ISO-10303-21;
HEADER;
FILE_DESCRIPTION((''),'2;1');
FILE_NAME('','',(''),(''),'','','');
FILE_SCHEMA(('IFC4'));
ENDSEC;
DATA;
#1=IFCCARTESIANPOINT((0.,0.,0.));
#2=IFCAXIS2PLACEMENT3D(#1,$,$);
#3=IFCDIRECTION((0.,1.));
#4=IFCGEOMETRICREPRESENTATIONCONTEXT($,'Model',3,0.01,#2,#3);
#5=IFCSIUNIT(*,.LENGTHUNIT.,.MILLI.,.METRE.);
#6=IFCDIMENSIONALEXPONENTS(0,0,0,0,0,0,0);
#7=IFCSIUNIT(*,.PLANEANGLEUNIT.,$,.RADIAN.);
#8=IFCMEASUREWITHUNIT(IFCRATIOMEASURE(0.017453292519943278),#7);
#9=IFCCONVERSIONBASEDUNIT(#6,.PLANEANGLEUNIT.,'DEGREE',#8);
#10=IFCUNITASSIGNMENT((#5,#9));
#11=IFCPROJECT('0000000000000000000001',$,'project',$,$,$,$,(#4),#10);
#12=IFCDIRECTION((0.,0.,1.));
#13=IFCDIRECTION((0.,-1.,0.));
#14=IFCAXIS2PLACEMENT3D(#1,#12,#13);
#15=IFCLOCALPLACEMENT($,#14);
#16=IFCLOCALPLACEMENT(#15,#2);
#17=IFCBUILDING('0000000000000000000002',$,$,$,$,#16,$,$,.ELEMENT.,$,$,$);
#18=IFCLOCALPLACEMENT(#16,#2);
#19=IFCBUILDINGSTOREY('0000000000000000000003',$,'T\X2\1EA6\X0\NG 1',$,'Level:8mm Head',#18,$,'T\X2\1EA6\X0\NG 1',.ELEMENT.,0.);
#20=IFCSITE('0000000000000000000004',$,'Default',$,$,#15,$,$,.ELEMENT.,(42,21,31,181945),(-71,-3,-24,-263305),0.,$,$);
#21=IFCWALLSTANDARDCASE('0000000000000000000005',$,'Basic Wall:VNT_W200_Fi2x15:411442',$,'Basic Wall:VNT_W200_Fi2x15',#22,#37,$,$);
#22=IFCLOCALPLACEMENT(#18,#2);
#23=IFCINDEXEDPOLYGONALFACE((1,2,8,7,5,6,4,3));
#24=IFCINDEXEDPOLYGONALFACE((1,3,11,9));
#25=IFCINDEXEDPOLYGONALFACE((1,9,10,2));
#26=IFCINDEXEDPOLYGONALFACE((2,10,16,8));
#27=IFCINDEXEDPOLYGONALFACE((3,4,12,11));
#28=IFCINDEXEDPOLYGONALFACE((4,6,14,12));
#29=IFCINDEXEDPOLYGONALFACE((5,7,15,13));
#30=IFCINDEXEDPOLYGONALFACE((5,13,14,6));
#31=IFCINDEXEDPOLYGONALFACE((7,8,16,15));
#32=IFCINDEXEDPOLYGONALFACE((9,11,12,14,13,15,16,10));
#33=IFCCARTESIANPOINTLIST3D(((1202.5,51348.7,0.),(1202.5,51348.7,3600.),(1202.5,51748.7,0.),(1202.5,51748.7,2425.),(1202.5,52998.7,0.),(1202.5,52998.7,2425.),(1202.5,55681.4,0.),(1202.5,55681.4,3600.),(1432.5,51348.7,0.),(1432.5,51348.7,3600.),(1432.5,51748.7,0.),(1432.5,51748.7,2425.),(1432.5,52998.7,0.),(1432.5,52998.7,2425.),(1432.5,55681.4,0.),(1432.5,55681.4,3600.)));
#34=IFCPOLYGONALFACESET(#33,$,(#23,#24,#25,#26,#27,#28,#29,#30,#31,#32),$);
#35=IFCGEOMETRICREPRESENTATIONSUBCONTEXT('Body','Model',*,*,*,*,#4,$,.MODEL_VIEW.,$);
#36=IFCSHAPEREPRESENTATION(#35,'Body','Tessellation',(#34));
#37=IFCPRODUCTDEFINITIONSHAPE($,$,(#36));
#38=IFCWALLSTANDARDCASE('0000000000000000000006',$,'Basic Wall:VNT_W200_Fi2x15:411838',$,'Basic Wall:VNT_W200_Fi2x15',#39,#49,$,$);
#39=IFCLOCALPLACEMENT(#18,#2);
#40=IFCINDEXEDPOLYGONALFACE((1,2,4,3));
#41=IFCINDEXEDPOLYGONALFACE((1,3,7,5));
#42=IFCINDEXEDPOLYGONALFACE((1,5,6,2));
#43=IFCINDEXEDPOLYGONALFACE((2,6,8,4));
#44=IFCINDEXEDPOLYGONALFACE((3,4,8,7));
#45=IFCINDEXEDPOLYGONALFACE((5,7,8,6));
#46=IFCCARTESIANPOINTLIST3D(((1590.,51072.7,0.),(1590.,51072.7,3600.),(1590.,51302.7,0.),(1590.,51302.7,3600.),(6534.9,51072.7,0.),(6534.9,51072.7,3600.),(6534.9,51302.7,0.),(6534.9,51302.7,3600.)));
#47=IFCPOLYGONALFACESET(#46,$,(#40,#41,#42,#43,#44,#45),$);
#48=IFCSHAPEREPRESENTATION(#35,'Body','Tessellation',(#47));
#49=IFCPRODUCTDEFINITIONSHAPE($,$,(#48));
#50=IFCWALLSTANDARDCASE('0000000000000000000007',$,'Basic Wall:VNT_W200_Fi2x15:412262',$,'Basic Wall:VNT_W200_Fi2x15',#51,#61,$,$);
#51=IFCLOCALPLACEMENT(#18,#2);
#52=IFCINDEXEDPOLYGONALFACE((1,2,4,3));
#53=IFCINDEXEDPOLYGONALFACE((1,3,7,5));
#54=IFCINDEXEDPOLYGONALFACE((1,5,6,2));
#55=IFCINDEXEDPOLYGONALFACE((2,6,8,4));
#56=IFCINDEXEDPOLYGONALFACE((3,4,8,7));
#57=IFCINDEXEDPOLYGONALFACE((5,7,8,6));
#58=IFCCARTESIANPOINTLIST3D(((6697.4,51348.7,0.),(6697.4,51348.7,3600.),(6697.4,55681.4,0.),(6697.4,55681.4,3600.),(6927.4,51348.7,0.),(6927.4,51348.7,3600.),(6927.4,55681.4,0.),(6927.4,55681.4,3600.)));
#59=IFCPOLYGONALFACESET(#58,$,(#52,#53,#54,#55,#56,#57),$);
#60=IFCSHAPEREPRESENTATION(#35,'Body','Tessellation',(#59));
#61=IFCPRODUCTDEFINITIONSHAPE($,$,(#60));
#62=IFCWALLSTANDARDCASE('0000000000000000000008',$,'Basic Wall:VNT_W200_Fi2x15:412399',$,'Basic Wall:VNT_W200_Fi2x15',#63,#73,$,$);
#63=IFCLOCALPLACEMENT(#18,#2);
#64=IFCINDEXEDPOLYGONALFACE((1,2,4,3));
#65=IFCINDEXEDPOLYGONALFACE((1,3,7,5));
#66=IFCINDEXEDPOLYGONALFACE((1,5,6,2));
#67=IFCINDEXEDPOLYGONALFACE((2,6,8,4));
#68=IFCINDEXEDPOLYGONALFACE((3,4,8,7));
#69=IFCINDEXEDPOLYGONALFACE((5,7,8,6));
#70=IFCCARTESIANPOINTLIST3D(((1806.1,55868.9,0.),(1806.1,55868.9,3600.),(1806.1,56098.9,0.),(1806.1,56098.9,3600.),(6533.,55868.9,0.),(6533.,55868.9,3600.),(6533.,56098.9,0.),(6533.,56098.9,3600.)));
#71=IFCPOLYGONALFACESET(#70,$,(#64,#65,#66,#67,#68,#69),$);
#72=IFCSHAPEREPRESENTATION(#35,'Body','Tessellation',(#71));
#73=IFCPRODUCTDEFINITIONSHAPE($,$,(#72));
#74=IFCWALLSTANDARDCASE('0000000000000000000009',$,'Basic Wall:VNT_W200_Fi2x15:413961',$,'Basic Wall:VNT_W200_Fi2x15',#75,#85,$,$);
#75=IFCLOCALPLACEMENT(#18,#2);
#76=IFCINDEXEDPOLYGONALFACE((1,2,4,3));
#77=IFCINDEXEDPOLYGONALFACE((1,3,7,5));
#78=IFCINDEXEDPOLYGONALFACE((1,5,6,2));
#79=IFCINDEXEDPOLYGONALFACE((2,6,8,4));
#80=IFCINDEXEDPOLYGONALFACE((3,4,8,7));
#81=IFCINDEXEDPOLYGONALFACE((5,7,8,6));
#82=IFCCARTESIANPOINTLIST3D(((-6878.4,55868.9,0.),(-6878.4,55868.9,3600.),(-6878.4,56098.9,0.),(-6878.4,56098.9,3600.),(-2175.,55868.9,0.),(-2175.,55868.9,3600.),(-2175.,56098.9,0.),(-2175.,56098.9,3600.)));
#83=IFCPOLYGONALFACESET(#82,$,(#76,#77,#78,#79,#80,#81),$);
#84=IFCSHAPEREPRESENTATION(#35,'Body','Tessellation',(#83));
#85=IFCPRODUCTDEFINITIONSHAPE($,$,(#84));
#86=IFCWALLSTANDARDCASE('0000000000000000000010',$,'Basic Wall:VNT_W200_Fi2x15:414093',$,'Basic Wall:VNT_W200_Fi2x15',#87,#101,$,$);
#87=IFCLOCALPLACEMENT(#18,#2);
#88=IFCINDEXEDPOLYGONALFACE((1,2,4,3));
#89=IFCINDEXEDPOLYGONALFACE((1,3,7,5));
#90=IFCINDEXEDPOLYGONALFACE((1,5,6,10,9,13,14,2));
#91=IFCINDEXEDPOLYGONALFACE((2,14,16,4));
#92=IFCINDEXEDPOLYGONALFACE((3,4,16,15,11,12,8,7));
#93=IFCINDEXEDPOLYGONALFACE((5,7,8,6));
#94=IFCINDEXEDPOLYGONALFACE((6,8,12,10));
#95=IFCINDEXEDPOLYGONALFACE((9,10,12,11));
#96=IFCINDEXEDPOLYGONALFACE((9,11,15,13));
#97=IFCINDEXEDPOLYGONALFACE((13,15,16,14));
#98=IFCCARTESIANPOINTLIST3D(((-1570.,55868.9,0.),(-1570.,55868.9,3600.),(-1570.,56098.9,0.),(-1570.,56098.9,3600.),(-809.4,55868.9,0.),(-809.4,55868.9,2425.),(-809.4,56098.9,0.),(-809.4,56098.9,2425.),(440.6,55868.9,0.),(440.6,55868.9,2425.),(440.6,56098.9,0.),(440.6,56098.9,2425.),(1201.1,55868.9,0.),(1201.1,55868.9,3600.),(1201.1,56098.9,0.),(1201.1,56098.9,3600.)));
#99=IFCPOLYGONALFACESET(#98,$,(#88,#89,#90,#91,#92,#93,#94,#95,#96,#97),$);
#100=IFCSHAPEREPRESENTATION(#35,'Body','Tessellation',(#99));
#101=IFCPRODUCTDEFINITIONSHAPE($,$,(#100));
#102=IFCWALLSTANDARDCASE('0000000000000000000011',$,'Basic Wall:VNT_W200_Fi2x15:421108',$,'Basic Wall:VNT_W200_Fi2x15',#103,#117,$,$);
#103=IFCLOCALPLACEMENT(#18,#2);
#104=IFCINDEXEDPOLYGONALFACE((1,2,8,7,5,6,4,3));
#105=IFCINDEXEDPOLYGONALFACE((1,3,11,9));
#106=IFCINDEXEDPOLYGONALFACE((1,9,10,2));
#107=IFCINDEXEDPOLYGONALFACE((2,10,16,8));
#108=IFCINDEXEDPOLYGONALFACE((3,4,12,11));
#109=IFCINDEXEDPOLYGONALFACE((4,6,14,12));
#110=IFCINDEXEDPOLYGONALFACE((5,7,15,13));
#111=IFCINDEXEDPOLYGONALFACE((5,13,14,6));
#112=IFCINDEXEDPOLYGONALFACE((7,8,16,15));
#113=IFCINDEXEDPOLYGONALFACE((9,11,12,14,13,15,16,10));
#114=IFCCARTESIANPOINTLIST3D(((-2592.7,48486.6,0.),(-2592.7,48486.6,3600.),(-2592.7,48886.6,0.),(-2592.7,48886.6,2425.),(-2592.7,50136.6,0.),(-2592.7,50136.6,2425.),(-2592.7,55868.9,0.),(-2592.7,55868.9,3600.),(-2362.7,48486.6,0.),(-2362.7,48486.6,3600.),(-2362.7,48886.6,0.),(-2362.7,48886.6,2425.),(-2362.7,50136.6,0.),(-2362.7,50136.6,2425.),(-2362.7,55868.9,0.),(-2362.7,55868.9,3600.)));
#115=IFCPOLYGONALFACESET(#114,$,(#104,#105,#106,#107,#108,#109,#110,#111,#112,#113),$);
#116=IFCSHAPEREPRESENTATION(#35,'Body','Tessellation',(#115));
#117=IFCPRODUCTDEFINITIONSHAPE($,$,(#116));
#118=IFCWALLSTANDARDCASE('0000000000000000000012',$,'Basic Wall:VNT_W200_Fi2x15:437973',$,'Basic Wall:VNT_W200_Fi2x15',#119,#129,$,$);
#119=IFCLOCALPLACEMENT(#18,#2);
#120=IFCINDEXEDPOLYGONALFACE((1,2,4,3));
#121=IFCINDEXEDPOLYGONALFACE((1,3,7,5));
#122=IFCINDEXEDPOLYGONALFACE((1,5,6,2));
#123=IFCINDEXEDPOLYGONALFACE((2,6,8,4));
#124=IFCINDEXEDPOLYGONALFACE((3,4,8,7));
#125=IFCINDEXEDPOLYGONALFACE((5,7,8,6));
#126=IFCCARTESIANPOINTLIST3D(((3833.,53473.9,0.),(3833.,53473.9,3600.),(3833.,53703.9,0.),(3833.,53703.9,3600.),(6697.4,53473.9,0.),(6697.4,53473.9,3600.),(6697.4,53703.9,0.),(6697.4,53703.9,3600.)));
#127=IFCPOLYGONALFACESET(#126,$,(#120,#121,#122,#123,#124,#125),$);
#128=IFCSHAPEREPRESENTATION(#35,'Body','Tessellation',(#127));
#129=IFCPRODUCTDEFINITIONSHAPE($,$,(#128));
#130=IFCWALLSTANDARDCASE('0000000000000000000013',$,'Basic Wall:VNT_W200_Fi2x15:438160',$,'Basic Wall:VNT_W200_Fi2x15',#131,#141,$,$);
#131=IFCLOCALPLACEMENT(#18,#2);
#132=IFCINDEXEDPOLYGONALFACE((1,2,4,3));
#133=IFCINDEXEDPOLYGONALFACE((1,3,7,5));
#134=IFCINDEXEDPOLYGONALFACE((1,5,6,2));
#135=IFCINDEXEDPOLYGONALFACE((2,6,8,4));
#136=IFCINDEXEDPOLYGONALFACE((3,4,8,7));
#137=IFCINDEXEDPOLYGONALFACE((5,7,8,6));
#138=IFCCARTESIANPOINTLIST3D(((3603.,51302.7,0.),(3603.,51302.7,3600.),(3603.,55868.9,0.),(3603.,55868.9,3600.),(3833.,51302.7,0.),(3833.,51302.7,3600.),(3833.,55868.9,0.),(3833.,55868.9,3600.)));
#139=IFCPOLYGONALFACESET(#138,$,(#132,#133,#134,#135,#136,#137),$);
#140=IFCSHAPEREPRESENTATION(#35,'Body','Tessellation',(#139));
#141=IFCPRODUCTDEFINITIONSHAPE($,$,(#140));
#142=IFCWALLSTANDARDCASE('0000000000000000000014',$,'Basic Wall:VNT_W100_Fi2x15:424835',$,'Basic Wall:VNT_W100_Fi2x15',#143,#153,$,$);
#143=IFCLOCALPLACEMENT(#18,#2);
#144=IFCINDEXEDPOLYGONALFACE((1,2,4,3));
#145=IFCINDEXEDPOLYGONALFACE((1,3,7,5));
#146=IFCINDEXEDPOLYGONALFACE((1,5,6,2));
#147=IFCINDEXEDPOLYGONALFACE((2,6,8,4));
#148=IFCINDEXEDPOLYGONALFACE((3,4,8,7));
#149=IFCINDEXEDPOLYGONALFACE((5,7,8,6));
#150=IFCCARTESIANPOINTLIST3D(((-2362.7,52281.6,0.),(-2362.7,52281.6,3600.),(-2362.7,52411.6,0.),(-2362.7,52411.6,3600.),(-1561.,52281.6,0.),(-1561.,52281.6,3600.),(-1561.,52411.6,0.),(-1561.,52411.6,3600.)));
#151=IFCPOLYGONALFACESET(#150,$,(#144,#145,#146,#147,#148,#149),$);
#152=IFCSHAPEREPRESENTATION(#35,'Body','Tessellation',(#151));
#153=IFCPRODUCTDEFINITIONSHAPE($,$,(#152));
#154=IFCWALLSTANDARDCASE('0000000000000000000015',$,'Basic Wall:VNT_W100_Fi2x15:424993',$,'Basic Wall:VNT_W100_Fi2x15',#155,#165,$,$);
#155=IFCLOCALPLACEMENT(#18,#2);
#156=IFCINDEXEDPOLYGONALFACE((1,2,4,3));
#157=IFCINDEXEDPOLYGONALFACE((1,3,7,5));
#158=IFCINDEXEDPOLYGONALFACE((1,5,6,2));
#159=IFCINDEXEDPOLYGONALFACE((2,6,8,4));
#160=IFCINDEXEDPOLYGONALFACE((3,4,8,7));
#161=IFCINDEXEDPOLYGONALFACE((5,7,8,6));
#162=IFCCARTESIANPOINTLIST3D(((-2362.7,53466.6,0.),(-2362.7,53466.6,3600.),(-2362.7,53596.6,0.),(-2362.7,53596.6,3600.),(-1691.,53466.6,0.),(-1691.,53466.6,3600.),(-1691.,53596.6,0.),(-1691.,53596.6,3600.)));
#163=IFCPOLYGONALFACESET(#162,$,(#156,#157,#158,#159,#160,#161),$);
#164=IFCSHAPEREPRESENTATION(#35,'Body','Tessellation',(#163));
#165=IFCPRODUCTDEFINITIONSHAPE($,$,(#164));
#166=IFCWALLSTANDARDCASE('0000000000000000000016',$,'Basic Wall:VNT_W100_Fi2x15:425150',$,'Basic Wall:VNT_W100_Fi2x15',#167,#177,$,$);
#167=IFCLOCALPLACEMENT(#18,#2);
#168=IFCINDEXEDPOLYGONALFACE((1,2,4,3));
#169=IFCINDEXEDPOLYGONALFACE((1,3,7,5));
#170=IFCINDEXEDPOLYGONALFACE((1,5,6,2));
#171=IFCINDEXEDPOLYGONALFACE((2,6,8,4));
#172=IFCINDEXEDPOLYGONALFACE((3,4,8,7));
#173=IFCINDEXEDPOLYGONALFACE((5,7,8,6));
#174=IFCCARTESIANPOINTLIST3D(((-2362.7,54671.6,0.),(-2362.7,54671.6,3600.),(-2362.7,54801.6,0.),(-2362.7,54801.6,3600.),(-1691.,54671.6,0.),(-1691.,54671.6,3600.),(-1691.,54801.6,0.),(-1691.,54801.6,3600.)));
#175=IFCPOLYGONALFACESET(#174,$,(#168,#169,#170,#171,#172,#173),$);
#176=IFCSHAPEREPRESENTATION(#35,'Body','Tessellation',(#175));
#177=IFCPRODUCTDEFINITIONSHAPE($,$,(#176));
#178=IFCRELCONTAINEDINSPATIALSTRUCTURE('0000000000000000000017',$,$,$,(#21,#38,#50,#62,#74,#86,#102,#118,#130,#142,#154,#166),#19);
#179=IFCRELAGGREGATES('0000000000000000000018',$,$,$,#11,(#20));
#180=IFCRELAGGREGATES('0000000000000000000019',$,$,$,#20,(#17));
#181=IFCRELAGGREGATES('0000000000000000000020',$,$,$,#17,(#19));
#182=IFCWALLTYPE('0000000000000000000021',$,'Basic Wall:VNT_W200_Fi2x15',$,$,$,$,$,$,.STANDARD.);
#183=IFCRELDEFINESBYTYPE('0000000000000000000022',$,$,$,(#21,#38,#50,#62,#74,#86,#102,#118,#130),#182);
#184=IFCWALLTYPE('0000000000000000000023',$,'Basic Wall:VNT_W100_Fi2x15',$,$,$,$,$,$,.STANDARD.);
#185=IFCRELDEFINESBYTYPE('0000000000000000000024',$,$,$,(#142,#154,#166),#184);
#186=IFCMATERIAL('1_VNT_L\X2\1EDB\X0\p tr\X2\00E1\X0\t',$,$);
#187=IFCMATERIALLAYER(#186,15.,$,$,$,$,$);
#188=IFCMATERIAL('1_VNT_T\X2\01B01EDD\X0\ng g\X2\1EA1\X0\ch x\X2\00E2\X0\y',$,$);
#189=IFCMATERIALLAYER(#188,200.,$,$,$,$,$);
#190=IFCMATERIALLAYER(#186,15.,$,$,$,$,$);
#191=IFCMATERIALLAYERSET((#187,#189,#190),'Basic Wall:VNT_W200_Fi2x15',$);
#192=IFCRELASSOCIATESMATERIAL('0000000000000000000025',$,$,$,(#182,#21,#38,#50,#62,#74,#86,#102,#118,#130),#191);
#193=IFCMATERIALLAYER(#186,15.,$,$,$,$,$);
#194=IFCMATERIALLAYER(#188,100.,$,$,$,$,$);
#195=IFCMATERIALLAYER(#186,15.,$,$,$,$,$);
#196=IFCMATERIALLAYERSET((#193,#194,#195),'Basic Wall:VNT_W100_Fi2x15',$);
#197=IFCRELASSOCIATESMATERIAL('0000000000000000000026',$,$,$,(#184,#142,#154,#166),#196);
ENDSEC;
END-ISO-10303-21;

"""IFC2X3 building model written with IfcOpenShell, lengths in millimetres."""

from ifc_helpers import new_model, entity, si_unit, converted_unit, direction, frame, frame_2d, origin, place, context, subcontext, project, spatial, rectangle, extrude, material, layer, layer_set, layer_usage, type_object, element, save


model = new_model("IFC2X3")

# Units and contexts
model_context = context("Model", 3, precision=0.01, world=origin(), true_north=direction((0.0, 1.0)))
body_context = subcontext(model_context, "Body", "Model", "MODEL_VIEW")
ifc_project = project(units=[si_unit("LENGTHUNIT", "METRE", prefix="MILLI"), converted_unit("PLANEANGLEUNIT", "DEGREE", entity("IfcRatioMeasure", 0.017453292519943278), si_unit("PLANEANGLEUNIT", "RADIAN"), dimensions=[0, 0, 0, 0, 0, 0, 0])], contexts=[model_context])

# Site, building, storey
site_placement = place(None, frame((0.0, 0.0, 0.0), z_axis=(0.0, 0.0, 1.0), x_axis=(0.0, -1.0, 0.0)))
site = spatial("IfcSite", under=ifc_project, at=site_placement, Name="Default", CompositionType="ELEMENT", RefLatitude=(42, 21, 31, 181945), RefLongitude=(-71, -3, -24, -263305), RefElevation=0.0)
building_placement = place(site_placement, origin())
building = spatial("IfcBuilding", under=site, at=building_placement, CompositionType="ELEMENT")
storey_placement = place(building_placement, origin())
storey = spatial("IfcBuildingStorey", under=building, at=storey_placement, Name="TẦNG 1", ObjectType="Level:8mm Head", LongName="TẦNG 1", CompositionType="ELEMENT", Elevation=0.0)

# Wall, opening
ifc_material_1 = material(Name="1_VNT_Lớp trát")
ifc_layer_1 = layer(ifc_material_1, 15.0)
ifc_material_2 = material(Name="1_VNT_Tường gạch xây")
ifc_layer_2 = layer(ifc_material_2, 200.0)
ifc_layer_3 = layer(ifc_material_1, 15.0)
ifc_layer_set_1 = layer_set([ifc_layer_1, ifc_layer_2, ifc_layer_3], Name="Basic Wall:VNT_W200_Fi2x15")
ifc_layer_usage_1 = layer_usage(ifc_layer_set_1, "AXIS2", "NEGATIVE", 115.0)
wall_type_1 = type_object("IfcWallType", Name="Basic Wall:VNT_W200_Fi2x15", PredefinedType="STANDARD", material=ifc_layer_set_1)
wall_1_placement = place(storey_placement, frame((1317.5, 51348.7, 0.0), z_axis=(0.0, 0.0, 1.0), x_axis=(0.0, 1.0, 0.0)))
wall_1 = element("IfcWallStandardCase", 1, at=wall_1_placement, inside=storey, type_object=wall_type_1, material=ifc_layer_usage_1, Name="Basic Wall:VNT_W200_Fi2x15:411442", ObjectType="Basic Wall:VNT_W200_Fi2x15", context=body_context, shape_type="SweptSolid", body=[
    extrude(rectangle(XDim=4332.7, YDim=230.0, at=frame_2d((2166.4, 0.0), x_axis=(1.0, 0.0))), origin(), (0.0, 0.0, 1.0), 3600.0),
])
opening_1_placement = place(wall_1_placement, frame((400.0, -115.0, 0.0)))
element("IfcOpeningElement", 2, at=opening_1_placement, cuts=wall_1, ObjectType="Opening", context=body_context, shape_type="SweptSolid", body=[
    extrude(rectangle(XDim=2425.0, YDim=1250.0, at=frame_2d((1212.5, 625.0), x_axis=(1.0, 0.0))), frame((0.0, 0.0, 0.0), z_axis=(0.0, 1.0, 0.0), x_axis=(0.0, 0.0, 1.0)), (0.0, 0.0, 1.0), 230.0),
])

# Walls
wall_2_placement = place(storey_placement, frame((1590.0, 51187.7, 0.0)))
element("IfcWallStandardCase", 3, at=wall_2_placement, inside=storey, type_object=wall_type_1, material=ifc_layer_usage_1, Name="Basic Wall:VNT_W200_Fi2x15:411838", ObjectType="Basic Wall:VNT_W200_Fi2x15", context=body_context, shape_type="SweptSolid", body=[
    extrude(rectangle(XDim=4944.9, YDim=230.0, at=frame_2d((2472.5, 0.0), x_axis=(-1.0, 0.0))), origin(), (0.0, 0.0, 1.0), 3600.0),
])
wall_3_placement = place(storey_placement, frame((6812.4, 51348.7, 0.0), z_axis=(0.0, 0.0, 1.0), x_axis=(0.0, 1.0, 0.0)))
element("IfcWallStandardCase", 4, at=wall_3_placement, inside=storey, type_object=wall_type_1, material=ifc_layer_usage_1, Name="Basic Wall:VNT_W200_Fi2x15:412262", ObjectType="Basic Wall:VNT_W200_Fi2x15", context=body_context, shape_type="SweptSolid", body=[
    extrude(rectangle(XDim=4332.7, YDim=230.0, at=frame_2d((2166.4, 0.0), x_axis=(-1.0, 0.0))), origin(), (0.0, 0.0, 1.0), 3600.0),
])
wall_4_placement = place(storey_placement, frame((6533.0, 55983.9, 0.0), z_axis=(0.0, 0.0, 1.0), x_axis=(-1.0, 0.0, 0.0)))
element("IfcWallStandardCase", 5, at=wall_4_placement, inside=storey, type_object=wall_type_1, material=ifc_layer_usage_1, Name="Basic Wall:VNT_W200_Fi2x15:412399", ObjectType="Basic Wall:VNT_W200_Fi2x15", context=body_context, shape_type="SweptSolid", body=[
    extrude(rectangle(XDim=4726.9, YDim=230.0, at=frame_2d((2363.5, 0.0), x_axis=(-1.0, 0.0))), origin(), (0.0, 0.0, 1.0), 3600.0),
])
wall_5_placement = place(storey_placement, frame((-6878.4, 55983.9, 0.0)))
element("IfcWallStandardCase", 6, at=wall_5_placement, inside=storey, type_object=wall_type_1, material=ifc_layer_usage_1, Name="Basic Wall:VNT_W200_Fi2x15:413961", ObjectType="Basic Wall:VNT_W200_Fi2x15", context=body_context, shape_type="SweptSolid", body=[
    extrude(rectangle(XDim=4703.5, YDim=230.0, at=frame_2d((2351.7, 0.0), x_axis=(-1.0, 0.0))), origin(), (0.0, 0.0, 1.0), 3600.0),
])

# Walls, openings
wall_6_placement = place(storey_placement, frame((-1570.0, 55983.9, 0.0)))
wall_6 = element("IfcWallStandardCase", 7, at=wall_6_placement, inside=storey, type_object=wall_type_1, material=ifc_layer_usage_1, Name="Basic Wall:VNT_W200_Fi2x15:414093", ObjectType="Basic Wall:VNT_W200_Fi2x15", context=body_context, shape_type="SweptSolid", body=[
    extrude(rectangle(XDim=2771.1, YDim=230.0, at=frame_2d((1385.6, 0.0), x_axis=(-1.0, 0.0))), origin(), (0.0, 0.0, 1.0), 3600.0),
])
opening_2_placement = place(wall_6_placement, frame((760.6, -115.0, 0.0)))
element("IfcOpeningElement", 8, at=opening_2_placement, cuts=wall_6, ObjectType="Opening", context=body_context, shape_type="SweptSolid", body=[
    extrude(rectangle(XDim=2425.0, YDim=1250.0, at=frame_2d((1212.5, 625.0), x_axis=(1.0, 0.0))), frame((0.0, 0.0, 0.0), z_axis=(0.0, 1.0, 0.0), x_axis=(0.0, 0.0, 1.0)), (0.0, 0.0, 1.0), 230.0),
])
wall_7_placement = place(storey_placement, frame((-2477.7, 55868.9, 0.0), z_axis=(0.0, 0.0, 1.0), x_axis=(0.0, -1.0, 0.0)))
wall_7 = element("IfcWallStandardCase", 9, at=wall_7_placement, inside=storey, type_object=wall_type_1, material=ifc_layer_usage_1, Name="Basic Wall:VNT_W200_Fi2x15:421108", ObjectType="Basic Wall:VNT_W200_Fi2x15", context=body_context, shape_type="SweptSolid", body=[
    extrude(rectangle(XDim=7382.3, YDim=230.0, at=frame_2d((3691.1, 0.0), x_axis=(1.0, 0.0))), origin(), (0.0, 0.0, 1.0), 3600.0),
])
opening_3_placement = place(wall_7_placement, frame((6982.3, 115.0, 0.0)))
element("IfcOpeningElement", 10, at=opening_3_placement, cuts=wall_7, ObjectType="Opening", context=body_context, shape_type="SweptSolid", body=[
    extrude(rectangle(XDim=2425.0, YDim=1250.0, at=frame_2d((1212.5, 625.0), x_axis=(1.0, 0.0))), frame((0.0, 0.0, 0.0), z_axis=(0.0, -1.0, 0.0), x_axis=(0.0, 0.0, 1.0)), (0.0, 0.0, 1.0), 230.0),
])

# Walls
wall_8_placement = place(storey_placement, frame((6697.4, 53588.9, 0.0), z_axis=(0.0, 0.0, 1.0), x_axis=(-1.0, 0.0, 0.0)))
element("IfcWallStandardCase", 11, at=wall_8_placement, inside=storey, type_object=wall_type_1, material=ifc_layer_usage_1, Name="Basic Wall:VNT_W200_Fi2x15:437973", ObjectType="Basic Wall:VNT_W200_Fi2x15", context=body_context, shape_type="SweptSolid", body=[
    extrude(rectangle(XDim=2864.4, YDim=230.0, at=frame_2d((1432.2, 0.0), x_axis=(-1.0, 0.0))), origin(), (0.0, 0.0, 1.0), 3600.0),
])
wall_9_placement = place(storey_placement, frame((3718.0, 51302.7, 0.0), z_axis=(0.0, 0.0, 1.0), x_axis=(0.0, 1.0, 0.0)))
element("IfcWallStandardCase", 12, at=wall_9_placement, inside=storey, type_object=wall_type_1, material=ifc_layer_usage_1, Name="Basic Wall:VNT_W200_Fi2x15:438160", ObjectType="Basic Wall:VNT_W200_Fi2x15", context=body_context, shape_type="SweptSolid", body=[
    extrude(rectangle(XDim=4566.2, YDim=230.0, at=frame_2d((2283.1, 0.0), x_axis=(-1.0, 0.0))), origin(), (0.0, 0.0, 1.0), 3600.0),
])
ifc_layer_4 = layer(ifc_material_1, 15.0)
ifc_layer_5 = layer(ifc_material_2, 100.0)
ifc_layer_6 = layer(ifc_material_1, 15.0)
ifc_layer_set_2 = layer_set([ifc_layer_4, ifc_layer_5, ifc_layer_6], Name="Basic Wall:VNT_W100_Fi2x15")
ifc_layer_usage_2 = layer_usage(ifc_layer_set_2, "AXIS2", "NEGATIVE", 65.0)
wall_type_2 = type_object("IfcWallType", Name="Basic Wall:VNT_W100_Fi2x15", PredefinedType="STANDARD", material=ifc_layer_set_2)
wall_10_placement = place(storey_placement, frame((-2362.7, 52346.6, 0.0)))
element("IfcWallStandardCase", 13, at=wall_10_placement, inside=storey, type_object=wall_type_2, material=ifc_layer_usage_2, Name="Basic Wall:VNT_W100_Fi2x15:424835", ObjectType="Basic Wall:VNT_W100_Fi2x15", context=body_context, shape_type="SweptSolid", body=[
    extrude(rectangle(XDim=801.6, YDim=130.0, at=frame_2d((400.8, 0.0), x_axis=(-1.0, 0.0))), origin(), (0.0, 0.0, 1.0), 3600.0),
])
for number, where, name in (
    (14, (-2362.7, 53531.6, 0.0), "Basic Wall:VNT_W100_Fi2x15:424993"),
    (15, (-2362.7, 54736.6, 0.0), "Basic Wall:VNT_W100_Fi2x15:425150"),
):
    element("IfcWallStandardCase", number, at=place(storey_placement, frame(where)), inside=storey, type_object=wall_type_2, material=ifc_layer_usage_2, Name=name, ObjectType="Basic Wall:VNT_W100_Fi2x15", context=body_context, shape_type="SweptSolid", body=[
        extrude(rectangle(XDim=671.6, YDim=130.0, at=frame_2d((335.8, 0.0), x_axis=(-1.0, 0.0))), origin(), (0.0, 0.0, 1.0), 3600.0),
    ])

save(model, "model.ifc")
